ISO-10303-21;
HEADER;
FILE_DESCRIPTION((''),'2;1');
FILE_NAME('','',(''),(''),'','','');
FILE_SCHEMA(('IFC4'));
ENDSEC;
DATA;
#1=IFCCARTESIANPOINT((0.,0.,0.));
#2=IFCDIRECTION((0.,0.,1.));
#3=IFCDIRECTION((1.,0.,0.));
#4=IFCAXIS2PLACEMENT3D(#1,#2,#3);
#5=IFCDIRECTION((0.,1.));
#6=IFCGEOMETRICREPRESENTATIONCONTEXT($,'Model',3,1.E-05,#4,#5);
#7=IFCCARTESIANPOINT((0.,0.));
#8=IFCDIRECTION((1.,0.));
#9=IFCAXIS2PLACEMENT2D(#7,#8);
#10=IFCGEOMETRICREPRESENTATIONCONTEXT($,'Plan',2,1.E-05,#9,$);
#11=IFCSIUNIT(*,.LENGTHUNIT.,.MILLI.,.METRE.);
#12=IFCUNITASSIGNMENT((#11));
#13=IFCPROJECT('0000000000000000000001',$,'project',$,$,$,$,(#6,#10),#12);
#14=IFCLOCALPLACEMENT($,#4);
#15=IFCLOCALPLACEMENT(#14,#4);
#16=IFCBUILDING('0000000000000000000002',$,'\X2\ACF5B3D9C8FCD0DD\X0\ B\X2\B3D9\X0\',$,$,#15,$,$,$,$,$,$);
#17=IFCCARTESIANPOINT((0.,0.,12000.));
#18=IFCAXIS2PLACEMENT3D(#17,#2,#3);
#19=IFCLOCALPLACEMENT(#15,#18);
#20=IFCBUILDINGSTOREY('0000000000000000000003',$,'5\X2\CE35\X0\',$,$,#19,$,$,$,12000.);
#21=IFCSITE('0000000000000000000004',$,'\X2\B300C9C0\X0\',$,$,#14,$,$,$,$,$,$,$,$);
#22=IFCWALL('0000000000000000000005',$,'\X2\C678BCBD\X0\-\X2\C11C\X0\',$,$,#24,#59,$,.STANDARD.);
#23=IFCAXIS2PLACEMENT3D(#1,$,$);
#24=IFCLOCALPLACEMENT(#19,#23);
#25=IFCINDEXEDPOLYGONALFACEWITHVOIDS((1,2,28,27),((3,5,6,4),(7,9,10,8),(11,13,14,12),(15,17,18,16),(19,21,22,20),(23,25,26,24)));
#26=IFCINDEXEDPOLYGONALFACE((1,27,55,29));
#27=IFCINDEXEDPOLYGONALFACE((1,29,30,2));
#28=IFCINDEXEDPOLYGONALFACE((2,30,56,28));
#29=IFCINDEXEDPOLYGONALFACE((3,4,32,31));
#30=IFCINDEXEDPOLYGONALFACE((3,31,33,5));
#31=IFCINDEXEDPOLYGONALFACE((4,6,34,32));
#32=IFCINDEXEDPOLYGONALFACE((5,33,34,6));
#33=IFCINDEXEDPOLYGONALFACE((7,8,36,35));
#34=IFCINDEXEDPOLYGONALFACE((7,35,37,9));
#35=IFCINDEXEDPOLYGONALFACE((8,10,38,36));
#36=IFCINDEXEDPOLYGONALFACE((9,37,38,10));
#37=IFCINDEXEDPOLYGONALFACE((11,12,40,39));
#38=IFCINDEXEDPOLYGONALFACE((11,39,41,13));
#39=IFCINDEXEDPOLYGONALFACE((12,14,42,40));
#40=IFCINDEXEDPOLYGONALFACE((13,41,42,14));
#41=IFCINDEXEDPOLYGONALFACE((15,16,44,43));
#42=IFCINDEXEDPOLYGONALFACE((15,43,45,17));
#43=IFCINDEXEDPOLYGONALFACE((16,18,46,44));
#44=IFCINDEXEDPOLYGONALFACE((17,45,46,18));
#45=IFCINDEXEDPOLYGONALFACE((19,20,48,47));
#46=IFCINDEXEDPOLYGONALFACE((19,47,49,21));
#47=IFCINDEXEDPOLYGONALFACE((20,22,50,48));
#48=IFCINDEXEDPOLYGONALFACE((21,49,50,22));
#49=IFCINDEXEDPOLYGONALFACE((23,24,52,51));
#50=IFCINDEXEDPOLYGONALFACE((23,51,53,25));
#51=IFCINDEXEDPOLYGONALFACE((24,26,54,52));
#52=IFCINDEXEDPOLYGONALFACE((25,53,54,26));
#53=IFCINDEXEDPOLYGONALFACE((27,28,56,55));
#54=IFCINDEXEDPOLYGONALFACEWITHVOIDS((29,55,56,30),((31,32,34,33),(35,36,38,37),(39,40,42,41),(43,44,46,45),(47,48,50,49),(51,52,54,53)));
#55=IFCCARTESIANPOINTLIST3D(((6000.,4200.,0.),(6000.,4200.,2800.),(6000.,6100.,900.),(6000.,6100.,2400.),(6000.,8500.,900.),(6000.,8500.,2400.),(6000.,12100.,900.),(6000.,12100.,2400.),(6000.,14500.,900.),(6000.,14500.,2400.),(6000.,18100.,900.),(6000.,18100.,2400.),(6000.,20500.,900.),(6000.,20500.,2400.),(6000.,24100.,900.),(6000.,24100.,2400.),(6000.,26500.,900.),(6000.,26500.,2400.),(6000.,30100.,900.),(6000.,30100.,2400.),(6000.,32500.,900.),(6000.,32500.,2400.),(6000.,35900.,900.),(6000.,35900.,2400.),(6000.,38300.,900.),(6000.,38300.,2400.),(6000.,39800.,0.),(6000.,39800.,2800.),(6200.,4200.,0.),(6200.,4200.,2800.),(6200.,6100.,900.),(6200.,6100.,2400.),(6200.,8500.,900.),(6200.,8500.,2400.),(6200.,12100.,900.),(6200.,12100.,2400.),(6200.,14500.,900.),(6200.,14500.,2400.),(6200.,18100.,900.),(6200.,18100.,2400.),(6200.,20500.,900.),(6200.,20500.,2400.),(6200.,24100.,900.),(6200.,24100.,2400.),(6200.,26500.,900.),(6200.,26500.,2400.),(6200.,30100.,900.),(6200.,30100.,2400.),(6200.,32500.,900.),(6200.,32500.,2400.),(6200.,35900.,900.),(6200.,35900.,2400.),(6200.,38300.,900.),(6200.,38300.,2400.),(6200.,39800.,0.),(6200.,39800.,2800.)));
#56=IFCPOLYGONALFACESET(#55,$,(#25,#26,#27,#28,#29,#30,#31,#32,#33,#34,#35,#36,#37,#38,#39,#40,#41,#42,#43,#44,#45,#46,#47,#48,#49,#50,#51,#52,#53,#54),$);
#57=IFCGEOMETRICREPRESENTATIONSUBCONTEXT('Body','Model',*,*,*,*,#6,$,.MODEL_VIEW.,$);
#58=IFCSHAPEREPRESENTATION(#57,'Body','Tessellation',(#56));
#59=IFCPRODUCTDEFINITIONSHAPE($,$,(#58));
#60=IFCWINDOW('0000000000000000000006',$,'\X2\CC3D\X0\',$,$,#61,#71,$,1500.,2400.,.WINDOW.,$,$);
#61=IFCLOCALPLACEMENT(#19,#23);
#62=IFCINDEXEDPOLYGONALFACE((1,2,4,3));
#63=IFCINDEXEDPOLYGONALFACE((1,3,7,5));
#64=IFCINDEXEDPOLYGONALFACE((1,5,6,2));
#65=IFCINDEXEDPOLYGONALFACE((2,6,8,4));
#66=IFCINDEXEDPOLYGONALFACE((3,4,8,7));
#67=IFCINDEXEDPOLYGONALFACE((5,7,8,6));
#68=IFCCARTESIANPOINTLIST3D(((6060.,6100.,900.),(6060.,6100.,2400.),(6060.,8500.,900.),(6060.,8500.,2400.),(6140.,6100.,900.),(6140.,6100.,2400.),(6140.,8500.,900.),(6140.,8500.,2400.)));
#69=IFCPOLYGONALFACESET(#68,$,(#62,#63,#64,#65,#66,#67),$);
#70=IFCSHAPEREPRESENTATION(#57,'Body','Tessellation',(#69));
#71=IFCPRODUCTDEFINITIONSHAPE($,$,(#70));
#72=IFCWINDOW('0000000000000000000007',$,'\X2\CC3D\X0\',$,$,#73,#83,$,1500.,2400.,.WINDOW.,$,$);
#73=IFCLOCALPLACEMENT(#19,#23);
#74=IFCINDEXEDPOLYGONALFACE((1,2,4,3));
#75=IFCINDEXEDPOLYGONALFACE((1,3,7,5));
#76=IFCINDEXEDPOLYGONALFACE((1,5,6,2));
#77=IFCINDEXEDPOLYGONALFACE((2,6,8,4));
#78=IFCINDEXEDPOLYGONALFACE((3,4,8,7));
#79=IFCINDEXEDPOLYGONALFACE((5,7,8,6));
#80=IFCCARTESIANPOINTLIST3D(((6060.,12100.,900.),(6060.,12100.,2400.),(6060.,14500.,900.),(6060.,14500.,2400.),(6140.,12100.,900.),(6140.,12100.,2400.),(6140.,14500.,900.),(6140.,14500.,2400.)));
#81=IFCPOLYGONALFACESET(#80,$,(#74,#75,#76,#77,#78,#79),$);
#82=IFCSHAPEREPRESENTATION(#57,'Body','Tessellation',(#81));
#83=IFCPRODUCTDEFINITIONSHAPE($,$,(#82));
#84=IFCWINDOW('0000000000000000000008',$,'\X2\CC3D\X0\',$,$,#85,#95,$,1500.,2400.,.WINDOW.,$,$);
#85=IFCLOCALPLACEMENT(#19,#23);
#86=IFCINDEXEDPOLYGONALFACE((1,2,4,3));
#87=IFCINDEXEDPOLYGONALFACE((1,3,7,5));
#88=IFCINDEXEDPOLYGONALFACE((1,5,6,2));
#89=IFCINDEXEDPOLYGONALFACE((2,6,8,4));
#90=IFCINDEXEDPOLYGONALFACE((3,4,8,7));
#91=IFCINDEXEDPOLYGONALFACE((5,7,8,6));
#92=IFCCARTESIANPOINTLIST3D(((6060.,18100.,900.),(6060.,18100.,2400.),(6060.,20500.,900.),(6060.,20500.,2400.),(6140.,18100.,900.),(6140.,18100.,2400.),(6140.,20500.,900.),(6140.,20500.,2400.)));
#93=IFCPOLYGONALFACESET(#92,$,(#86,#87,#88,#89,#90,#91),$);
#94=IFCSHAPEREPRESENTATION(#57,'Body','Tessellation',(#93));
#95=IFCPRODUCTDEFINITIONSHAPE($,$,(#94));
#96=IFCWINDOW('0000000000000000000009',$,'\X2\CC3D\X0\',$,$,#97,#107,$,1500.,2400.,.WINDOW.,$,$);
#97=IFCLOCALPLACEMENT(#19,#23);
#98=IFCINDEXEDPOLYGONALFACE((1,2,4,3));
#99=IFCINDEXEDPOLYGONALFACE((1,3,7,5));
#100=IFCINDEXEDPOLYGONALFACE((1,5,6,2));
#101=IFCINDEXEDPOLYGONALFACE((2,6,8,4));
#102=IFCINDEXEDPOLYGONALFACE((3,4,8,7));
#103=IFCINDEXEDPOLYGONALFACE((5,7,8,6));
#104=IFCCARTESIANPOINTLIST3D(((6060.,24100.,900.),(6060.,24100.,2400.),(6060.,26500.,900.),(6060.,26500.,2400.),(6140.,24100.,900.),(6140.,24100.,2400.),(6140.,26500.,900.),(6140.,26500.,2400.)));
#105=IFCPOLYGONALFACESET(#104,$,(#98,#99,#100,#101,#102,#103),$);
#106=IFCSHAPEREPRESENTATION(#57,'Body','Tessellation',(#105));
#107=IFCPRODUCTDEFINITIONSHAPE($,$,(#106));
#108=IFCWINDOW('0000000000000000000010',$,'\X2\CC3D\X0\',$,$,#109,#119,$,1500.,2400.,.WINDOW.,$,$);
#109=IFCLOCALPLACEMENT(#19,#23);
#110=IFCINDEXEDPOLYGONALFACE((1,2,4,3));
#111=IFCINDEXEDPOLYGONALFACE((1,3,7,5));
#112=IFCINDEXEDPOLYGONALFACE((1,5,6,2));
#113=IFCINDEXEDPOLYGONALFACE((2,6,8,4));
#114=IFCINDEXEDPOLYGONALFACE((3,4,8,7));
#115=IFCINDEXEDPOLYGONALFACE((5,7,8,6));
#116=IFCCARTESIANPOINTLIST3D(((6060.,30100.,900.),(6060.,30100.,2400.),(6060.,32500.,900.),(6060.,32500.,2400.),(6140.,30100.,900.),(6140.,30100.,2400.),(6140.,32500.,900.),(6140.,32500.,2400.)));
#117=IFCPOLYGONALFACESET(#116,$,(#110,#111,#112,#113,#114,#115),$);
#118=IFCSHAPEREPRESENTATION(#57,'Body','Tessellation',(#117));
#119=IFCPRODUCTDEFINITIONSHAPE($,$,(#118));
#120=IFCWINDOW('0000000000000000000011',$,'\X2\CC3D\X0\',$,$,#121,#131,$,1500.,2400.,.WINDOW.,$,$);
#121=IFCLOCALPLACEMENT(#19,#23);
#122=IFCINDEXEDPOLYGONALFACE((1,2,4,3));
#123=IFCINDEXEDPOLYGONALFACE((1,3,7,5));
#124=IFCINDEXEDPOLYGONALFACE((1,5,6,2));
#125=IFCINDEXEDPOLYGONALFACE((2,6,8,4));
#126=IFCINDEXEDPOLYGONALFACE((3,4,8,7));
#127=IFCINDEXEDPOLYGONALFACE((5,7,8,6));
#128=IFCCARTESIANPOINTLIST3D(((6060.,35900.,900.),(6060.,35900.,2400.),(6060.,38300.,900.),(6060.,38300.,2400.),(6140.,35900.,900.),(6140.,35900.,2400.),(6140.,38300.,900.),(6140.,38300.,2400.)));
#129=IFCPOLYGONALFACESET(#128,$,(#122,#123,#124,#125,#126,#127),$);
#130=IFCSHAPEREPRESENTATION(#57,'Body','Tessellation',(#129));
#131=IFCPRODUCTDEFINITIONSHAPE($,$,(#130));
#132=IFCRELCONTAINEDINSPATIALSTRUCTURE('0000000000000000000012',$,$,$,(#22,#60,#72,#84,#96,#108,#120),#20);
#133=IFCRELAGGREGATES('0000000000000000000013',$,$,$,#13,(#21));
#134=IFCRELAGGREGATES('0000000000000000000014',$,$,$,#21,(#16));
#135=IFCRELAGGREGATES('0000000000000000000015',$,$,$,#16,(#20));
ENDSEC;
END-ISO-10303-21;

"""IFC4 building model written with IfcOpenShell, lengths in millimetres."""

from ifc_helpers import new_model, si_unit, direction, frame, origin_with_axes, origin_2d_with_axis, place, context, subcontext, project, spatial, polyline, outline, extrude, element, fill, save


model = new_model("IFC4")

# Units and contexts
model_context = context("Model", 3, precision=1e-05, world=origin_with_axes(), true_north=direction((0.0, 1.0)))
plan_context = context("Plan", 2, precision=1e-05, world=origin_2d_with_axis())
body_context = subcontext(model_context, "Body", "Model", "MODEL_VIEW")
ifc_project = project(units=[si_unit("LENGTHUNIT", "METRE", prefix="MILLI")], contexts=[model_context, plan_context])

# Site, building, storey
site_placement = place(None, origin_with_axes())
site = spatial("IfcSite", under=ifc_project, at=site_placement, Name="대지")
building_placement = place(site_placement, origin_with_axes())
building = spatial("IfcBuilding", under=site, at=building_placement, Name="공동주택 B동")
storey_placement = place(building_placement, frame((0.0, 0.0, 12000.0), z_axis=(0.0, 0.0, 1.0), x_axis=(1.0, 0.0, 0.0)))
storey = spatial("IfcBuildingStorey", under=building, at=storey_placement, Name="5층", Elevation=12000.0)

# Wall, openings, windows
wall_1_placement = place(storey_placement, origin_with_axes())
wall_1 = element("IfcWall", 1, at=wall_1_placement, inside=storey, Name="외벽-서", PredefinedType="STANDARD", context=body_context, shape_type="SweptSolid", body=[
    extrude(outline(polyline([(6200.0, 39800.0), (6200.0, 4200.0), (6000.0, 4200.0), (6000.0, 39800.0), (6200.0, 39800.0)])), origin_with_axes(), (0.0, 0.0, 1.0), 2800.0),
])
opening_1_placement = place(storey_placement, origin_with_axes())
opening_1 = element("IfcOpeningElement", 2, at=opening_1_placement, cuts=wall_1, PredefinedType="OPENING", context=body_context, shape_type="SweptSolid", body=[
    extrude(outline(polyline([(5950.0, 8500.0), (5950.0, 6100.0), (6250.0, 6100.0), (6250.0, 8500.0), (5950.0, 8500.0)])), frame((0.0, 0.0, 900.0), z_axis=(0.0, 0.0, 1.0), x_axis=(1.0, 0.0, 0.0)), (0.0, 0.0, 1.0), 1500.0),
])
opening_2_placement = place(storey_placement, origin_with_axes())
opening_2 = element("IfcOpeningElement", 3, at=opening_2_placement, cuts=wall_1, PredefinedType="OPENING", context=body_context, shape_type="SweptSolid", body=[
    extrude(outline(polyline([(5950.0, 14500.0), (5950.0, 12100.0), (6250.0, 12100.0), (6250.0, 14500.0), (5950.0, 14500.0)])), frame((0.0, 0.0, 900.0), z_axis=(0.0, 0.0, 1.0), x_axis=(1.0, 0.0, 0.0)), (0.0, 0.0, 1.0), 1500.0),
])
opening_3_placement = place(storey_placement, origin_with_axes())
opening_3 = element("IfcOpeningElement", 4, at=opening_3_placement, cuts=wall_1, PredefinedType="OPENING", context=body_context, shape_type="SweptSolid", body=[
    extrude(outline(polyline([(5950.0, 20500.0), (5950.0, 18100.0), (6250.0, 18100.0), (6250.0, 20500.0), (5950.0, 20500.0)])), frame((0.0, 0.0, 900.0), z_axis=(0.0, 0.0, 1.0), x_axis=(1.0, 0.0, 0.0)), (0.0, 0.0, 1.0), 1500.0),
])
opening_4_placement = place(storey_placement, origin_with_axes())
opening_4 = element("IfcOpeningElement", 5, at=opening_4_placement, cuts=wall_1, PredefinedType="OPENING", context=body_context, shape_type="SweptSolid", body=[
    extrude(outline(polyline([(5950.0, 26500.0), (5950.0, 24100.0), (6250.0, 24100.0), (6250.0, 26500.0), (5950.0, 26500.0)])), frame((0.0, 0.0, 900.0), z_axis=(0.0, 0.0, 1.0), x_axis=(1.0, 0.0, 0.0)), (0.0, 0.0, 1.0), 1500.0),
])
opening_5_placement = place(storey_placement, origin_with_axes())
opening_5 = element("IfcOpeningElement", 6, at=opening_5_placement, cuts=wall_1, PredefinedType="OPENING", context=body_context, shape_type="SweptSolid", body=[
    extrude(outline(polyline([(5950.0, 32500.0), (5950.0, 30100.0), (6250.0, 30100.0), (6250.0, 32500.0), (5950.0, 32500.0)])), frame((0.0, 0.0, 900.0), z_axis=(0.0, 0.0, 1.0), x_axis=(1.0, 0.0, 0.0)), (0.0, 0.0, 1.0), 1500.0),
])
opening_6_placement = place(storey_placement, origin_with_axes())
opening_6 = element("IfcOpeningElement", 7, at=opening_6_placement, cuts=wall_1, PredefinedType="OPENING", context=body_context, shape_type="SweptSolid", body=[
    extrude(outline(polyline([(5950.0, 38300.0), (5950.0, 35900.0), (6250.0, 35900.0), (6250.0, 38300.0), (5950.0, 38300.0)])), frame((0.0, 0.0, 900.0), z_axis=(0.0, 0.0, 1.0), x_axis=(1.0, 0.0, 0.0)), (0.0, 0.0, 1.0), 1500.0),
])
window_1_placement = place(storey_placement, origin_with_axes())
window_1 = element("IfcWindow", 8, at=window_1_placement, inside=storey, Name="창", OverallHeight=1500.0, OverallWidth=2400.0, PredefinedType="WINDOW", context=body_context, shape_type="SweptSolid", body=[
    extrude(outline(polyline([(6060.0, 8500.0), (6060.0, 6100.0), (6140.0, 6100.0), (6140.0, 8500.0), (6060.0, 8500.0)])), frame((0.0, 0.0, 900.0), z_axis=(0.0, 0.0, 1.0), x_axis=(1.0, 0.0, 0.0)), (0.0, 0.0, 1.0), 1500.0),
])
fill(opening_1, window_1)
window_2_placement = place(storey_placement, origin_with_axes())
window_2 = element("IfcWindow", 9, at=window_2_placement, inside=storey, Name="창", OverallHeight=1500.0, OverallWidth=2400.0, PredefinedType="WINDOW", context=body_context, shape_type="SweptSolid", body=[
    extrude(outline(polyline([(6060.0, 14500.0), (6060.0, 12100.0), (6140.0, 12100.0), (6140.0, 14500.0), (6060.0, 14500.0)])), frame((0.0, 0.0, 900.0), z_axis=(0.0, 0.0, 1.0), x_axis=(1.0, 0.0, 0.0)), (0.0, 0.0, 1.0), 1500.0),
])
fill(opening_2, window_2)
window_3_placement = place(storey_placement, origin_with_axes())
window_3 = element("IfcWindow", 10, at=window_3_placement, inside=storey, Name="창", OverallHeight=1500.0, OverallWidth=2400.0, PredefinedType="WINDOW", context=body_context, shape_type="SweptSolid", body=[
    extrude(outline(polyline([(6060.0, 20500.0), (6060.0, 18100.0), (6140.0, 18100.0), (6140.0, 20500.0), (6060.0, 20500.0)])), frame((0.0, 0.0, 900.0), z_axis=(0.0, 0.0, 1.0), x_axis=(1.0, 0.0, 0.0)), (0.0, 0.0, 1.0), 1500.0),
])
fill(opening_3, window_3)
window_4_placement = place(storey_placement, origin_with_axes())
window_4 = element("IfcWindow", 11, at=window_4_placement, inside=storey, Name="창", OverallHeight=1500.0, OverallWidth=2400.0, PredefinedType="WINDOW", context=body_context, shape_type="SweptSolid", body=[
    extrude(outline(polyline([(6060.0, 26500.0), (6060.0, 24100.0), (6140.0, 24100.0), (6140.0, 26500.0), (6060.0, 26500.0)])), frame((0.0, 0.0, 900.0), z_axis=(0.0, 0.0, 1.0), x_axis=(1.0, 0.0, 0.0)), (0.0, 0.0, 1.0), 1500.0),
])
fill(opening_4, window_4)
window_5_placement = place(storey_placement, origin_with_axes())
window_5 = element("IfcWindow", 12, at=window_5_placement, inside=storey, Name="창", OverallHeight=1500.0, OverallWidth=2400.0, PredefinedType="WINDOW", context=body_context, shape_type="SweptSolid", body=[
    extrude(outline(polyline([(6060.0, 32500.0), (6060.0, 30100.0), (6140.0, 30100.0), (6140.0, 32500.0), (6060.0, 32500.0)])), frame((0.0, 0.0, 900.0), z_axis=(0.0, 0.0, 1.0), x_axis=(1.0, 0.0, 0.0)), (0.0, 0.0, 1.0), 1500.0),
])
fill(opening_5, window_5)
window_6_placement = place(storey_placement, origin_with_axes())
window_6 = element("IfcWindow", 13, at=window_6_placement, inside=storey, Name="창", OverallHeight=1500.0, OverallWidth=2400.0, PredefinedType="WINDOW", context=body_context, shape_type="SweptSolid", body=[
    extrude(outline(polyline([(6060.0, 38300.0), (6060.0, 35900.0), (6140.0, 35900.0), (6140.0, 38300.0), (6060.0, 38300.0)])), frame((0.0, 0.0, 900.0), z_axis=(0.0, 0.0, 1.0), x_axis=(1.0, 0.0, 0.0)), (0.0, 0.0, 1.0), 1500.0),
])
fill(opening_6, window_6)

save(model, "model.ifc")
